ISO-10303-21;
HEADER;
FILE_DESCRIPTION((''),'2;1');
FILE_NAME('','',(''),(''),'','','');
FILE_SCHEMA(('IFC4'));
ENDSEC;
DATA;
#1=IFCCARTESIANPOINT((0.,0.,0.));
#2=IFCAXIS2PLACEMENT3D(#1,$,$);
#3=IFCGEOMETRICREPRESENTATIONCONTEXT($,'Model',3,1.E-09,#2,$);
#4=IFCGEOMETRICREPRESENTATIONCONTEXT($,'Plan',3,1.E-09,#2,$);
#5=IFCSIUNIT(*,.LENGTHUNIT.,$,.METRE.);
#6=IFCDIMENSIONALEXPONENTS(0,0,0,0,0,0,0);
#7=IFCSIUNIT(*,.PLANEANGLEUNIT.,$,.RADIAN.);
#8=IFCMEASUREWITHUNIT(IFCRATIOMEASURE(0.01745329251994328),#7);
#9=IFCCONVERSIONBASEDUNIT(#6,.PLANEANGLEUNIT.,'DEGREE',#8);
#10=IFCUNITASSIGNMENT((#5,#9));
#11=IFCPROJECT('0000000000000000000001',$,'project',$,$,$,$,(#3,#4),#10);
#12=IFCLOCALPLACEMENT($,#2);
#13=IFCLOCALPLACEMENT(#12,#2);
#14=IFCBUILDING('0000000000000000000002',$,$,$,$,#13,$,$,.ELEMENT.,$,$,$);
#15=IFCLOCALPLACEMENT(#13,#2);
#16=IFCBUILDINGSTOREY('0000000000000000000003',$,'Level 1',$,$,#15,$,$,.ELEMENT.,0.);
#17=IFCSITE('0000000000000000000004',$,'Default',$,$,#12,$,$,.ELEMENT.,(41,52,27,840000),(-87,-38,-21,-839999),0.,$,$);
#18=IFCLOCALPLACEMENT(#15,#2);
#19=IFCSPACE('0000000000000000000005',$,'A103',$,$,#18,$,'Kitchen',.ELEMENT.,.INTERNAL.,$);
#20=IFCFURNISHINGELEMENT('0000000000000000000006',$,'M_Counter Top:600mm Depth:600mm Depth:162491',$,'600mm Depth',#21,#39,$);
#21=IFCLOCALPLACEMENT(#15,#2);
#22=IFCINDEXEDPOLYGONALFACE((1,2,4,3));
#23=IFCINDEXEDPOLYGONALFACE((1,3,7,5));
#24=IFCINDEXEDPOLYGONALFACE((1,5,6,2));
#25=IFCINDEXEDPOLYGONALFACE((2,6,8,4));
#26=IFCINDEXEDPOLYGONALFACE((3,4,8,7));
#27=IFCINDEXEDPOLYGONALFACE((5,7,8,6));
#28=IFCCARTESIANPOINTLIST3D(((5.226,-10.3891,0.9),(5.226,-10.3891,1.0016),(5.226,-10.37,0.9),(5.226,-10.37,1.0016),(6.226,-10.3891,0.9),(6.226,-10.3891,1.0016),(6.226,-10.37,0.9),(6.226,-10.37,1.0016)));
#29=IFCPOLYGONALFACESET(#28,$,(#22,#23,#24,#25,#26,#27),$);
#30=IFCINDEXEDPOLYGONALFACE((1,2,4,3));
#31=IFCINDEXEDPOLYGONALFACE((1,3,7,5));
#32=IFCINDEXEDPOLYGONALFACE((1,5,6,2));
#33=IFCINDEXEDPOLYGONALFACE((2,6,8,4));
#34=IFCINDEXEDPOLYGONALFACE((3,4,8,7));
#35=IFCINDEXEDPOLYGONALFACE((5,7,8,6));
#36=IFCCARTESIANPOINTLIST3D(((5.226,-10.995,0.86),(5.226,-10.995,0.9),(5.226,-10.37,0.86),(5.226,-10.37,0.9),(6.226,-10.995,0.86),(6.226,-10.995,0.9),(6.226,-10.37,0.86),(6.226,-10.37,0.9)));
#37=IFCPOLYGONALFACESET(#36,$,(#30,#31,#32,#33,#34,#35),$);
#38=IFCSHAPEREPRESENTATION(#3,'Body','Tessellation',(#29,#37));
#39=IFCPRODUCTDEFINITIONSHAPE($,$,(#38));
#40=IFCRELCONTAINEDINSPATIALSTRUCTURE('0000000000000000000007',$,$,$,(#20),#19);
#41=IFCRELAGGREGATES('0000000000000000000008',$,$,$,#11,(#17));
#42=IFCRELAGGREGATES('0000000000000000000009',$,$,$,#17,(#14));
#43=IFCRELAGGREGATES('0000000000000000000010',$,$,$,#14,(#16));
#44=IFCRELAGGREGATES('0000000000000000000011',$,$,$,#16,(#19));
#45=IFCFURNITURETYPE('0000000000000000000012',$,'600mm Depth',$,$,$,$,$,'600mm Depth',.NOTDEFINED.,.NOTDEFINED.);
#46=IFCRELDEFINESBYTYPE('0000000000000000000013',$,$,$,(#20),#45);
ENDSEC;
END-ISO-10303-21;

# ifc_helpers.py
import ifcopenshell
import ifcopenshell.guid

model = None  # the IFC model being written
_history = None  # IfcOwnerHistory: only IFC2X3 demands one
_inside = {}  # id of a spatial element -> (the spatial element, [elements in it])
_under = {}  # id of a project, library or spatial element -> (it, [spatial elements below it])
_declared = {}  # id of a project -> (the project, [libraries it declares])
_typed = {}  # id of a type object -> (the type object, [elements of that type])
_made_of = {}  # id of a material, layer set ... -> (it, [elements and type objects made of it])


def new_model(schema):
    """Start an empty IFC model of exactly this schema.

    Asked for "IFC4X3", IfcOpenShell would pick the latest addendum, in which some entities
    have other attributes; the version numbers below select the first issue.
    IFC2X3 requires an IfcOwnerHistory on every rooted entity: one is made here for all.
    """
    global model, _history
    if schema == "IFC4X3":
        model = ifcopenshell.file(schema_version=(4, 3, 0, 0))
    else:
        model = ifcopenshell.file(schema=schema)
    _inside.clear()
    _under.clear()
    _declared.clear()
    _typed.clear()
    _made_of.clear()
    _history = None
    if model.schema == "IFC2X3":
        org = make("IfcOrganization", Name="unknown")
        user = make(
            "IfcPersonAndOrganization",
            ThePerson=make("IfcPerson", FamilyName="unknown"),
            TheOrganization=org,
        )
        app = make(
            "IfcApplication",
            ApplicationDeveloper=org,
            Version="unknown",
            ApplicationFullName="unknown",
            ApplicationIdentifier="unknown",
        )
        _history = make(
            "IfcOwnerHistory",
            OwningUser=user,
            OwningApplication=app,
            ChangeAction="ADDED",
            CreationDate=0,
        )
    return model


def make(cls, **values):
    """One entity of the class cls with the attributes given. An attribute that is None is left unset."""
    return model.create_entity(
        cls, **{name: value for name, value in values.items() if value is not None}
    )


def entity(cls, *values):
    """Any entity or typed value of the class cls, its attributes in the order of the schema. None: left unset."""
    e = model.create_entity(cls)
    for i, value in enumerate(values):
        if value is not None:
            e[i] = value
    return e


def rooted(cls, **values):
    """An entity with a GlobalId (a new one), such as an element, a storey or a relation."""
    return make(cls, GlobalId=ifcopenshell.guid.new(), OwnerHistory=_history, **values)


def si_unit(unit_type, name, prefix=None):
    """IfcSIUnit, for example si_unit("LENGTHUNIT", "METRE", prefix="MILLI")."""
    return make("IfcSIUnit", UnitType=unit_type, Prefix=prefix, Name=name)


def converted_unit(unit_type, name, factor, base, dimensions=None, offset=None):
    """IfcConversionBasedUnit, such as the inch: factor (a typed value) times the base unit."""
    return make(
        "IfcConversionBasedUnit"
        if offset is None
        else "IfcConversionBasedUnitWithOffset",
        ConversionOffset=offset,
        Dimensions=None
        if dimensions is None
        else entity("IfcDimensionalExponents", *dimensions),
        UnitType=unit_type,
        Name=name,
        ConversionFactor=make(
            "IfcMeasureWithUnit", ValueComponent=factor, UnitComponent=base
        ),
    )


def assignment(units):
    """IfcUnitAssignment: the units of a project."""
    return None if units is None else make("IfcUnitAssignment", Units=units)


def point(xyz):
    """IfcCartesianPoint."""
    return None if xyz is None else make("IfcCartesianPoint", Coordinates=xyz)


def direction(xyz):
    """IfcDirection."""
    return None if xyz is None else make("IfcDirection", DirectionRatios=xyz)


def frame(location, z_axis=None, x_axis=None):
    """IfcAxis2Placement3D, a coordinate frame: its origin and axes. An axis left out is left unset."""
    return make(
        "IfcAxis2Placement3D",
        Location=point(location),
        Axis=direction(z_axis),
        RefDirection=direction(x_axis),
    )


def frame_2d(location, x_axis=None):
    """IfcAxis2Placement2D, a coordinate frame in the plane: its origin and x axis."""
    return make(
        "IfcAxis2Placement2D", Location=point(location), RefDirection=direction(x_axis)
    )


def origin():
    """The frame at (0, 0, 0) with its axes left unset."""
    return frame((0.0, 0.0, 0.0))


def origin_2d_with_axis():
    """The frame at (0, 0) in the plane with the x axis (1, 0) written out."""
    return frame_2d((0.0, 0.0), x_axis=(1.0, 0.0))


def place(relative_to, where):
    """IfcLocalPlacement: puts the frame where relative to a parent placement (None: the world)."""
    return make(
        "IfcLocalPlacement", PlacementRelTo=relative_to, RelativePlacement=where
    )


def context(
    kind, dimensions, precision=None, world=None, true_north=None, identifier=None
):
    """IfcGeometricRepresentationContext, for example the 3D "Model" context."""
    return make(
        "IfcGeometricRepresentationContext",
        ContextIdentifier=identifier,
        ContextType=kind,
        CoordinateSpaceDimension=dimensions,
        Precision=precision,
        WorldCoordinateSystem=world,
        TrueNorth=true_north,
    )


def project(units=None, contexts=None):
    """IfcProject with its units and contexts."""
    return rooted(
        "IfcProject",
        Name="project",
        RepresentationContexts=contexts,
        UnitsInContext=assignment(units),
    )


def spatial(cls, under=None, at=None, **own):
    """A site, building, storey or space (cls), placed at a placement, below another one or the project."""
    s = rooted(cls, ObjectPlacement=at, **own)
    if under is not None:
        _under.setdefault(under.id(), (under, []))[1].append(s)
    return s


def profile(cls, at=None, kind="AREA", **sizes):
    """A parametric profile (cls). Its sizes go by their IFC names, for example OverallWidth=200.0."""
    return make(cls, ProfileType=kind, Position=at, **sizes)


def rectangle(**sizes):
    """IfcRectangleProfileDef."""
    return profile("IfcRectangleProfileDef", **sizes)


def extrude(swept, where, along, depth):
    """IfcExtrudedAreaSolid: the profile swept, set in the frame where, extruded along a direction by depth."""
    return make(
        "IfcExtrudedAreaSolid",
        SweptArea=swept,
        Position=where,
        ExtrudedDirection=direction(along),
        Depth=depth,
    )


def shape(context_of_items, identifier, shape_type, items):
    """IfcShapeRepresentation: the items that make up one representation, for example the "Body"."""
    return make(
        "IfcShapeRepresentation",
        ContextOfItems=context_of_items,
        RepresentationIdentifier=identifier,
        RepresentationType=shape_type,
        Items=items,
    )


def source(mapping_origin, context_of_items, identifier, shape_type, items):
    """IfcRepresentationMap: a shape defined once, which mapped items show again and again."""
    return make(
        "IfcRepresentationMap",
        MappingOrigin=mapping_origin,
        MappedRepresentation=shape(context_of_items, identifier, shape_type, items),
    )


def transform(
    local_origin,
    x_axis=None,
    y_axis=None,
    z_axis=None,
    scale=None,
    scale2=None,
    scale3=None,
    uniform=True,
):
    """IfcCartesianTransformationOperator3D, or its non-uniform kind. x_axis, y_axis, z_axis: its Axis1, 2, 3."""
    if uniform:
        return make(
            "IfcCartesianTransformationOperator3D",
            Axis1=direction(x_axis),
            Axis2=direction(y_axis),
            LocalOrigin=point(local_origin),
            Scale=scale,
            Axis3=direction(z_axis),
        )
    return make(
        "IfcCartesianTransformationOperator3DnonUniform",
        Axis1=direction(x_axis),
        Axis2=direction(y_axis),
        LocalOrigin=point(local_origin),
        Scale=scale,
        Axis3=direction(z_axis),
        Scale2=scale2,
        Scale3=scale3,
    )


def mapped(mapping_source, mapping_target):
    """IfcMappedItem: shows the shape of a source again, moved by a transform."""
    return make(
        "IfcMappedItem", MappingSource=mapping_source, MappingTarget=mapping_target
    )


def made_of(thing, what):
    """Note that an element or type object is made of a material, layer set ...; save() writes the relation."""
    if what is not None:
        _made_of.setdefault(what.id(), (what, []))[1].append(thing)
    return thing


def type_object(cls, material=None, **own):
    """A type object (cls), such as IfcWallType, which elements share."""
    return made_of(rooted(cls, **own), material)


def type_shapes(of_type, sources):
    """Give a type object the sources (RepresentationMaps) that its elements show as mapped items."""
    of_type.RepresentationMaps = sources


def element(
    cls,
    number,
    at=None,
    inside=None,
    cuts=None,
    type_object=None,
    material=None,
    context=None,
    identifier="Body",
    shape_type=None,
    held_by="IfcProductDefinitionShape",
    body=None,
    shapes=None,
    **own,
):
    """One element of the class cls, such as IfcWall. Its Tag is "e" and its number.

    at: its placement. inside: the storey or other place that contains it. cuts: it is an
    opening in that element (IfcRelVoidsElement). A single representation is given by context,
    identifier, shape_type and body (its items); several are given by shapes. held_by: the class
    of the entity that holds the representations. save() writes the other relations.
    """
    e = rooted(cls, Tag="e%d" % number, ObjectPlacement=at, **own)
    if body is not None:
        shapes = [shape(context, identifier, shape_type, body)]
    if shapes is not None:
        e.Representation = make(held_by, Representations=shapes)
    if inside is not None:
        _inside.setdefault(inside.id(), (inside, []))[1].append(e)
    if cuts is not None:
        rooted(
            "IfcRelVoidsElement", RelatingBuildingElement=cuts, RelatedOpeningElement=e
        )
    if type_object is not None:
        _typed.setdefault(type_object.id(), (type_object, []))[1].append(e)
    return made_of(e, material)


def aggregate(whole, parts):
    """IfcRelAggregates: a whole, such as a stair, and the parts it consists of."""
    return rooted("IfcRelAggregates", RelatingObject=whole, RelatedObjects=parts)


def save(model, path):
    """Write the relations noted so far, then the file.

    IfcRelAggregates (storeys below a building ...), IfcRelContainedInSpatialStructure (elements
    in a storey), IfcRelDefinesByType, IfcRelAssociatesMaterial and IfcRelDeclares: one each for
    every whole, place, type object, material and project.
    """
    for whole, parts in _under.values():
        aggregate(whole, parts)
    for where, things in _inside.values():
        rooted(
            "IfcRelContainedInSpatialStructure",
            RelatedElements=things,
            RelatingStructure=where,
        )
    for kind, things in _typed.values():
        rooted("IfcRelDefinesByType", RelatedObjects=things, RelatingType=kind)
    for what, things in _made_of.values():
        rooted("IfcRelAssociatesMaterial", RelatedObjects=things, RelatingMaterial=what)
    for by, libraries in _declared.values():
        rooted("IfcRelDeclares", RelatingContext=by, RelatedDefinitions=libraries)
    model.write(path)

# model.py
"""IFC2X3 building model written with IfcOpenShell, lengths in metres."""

from ifc_helpers import new_model, entity, si_unit, converted_unit, frame, origin, origin_2d_with_axis, place, context, project, spatial, rectangle, extrude, source, transform, mapped, type_object, type_shapes, element, save


model = new_model("IFC2X3")

# Units and contexts
model_context = context("Model", 3, precision=1e-09, world=origin())
plan_context = context("Plan", 3, precision=1e-09, world=origin())
ifc_project = project(units=[si_unit("LENGTHUNIT", "METRE"), converted_unit("PLANEANGLEUNIT", "DEGREE", entity("IfcRatioMeasure", 0.01745329251994328), si_unit("PLANEANGLEUNIT", "RADIAN"), dimensions=[0, 0, 0, 0, 0, 0, 0])], contexts=[model_context, plan_context])

# Site, building, storey
site_placement = place(None, origin())
site = spatial("IfcSite", under=ifc_project, at=site_placement, Name="Default", CompositionType="ELEMENT", RefLatitude=(41, 52, 27, 840000), RefLongitude=(-87, -38, -21, -839999), RefElevation=0.0)
building_placement = place(site_placement, origin())
building = spatial("IfcBuilding", under=site, at=building_placement, CompositionType="ELEMENT")
storey_placement = place(building_placement, origin())
storey = spatial("IfcBuildingStorey", under=building, at=storey_placement, Name="Level 1", CompositionType="ELEMENT", Elevation=0.0)

# Shared definitions
space_placement = place(storey_placement, origin())
space = spatial("IfcSpace", under=storey, at=space_placement, Name="A103", LongName="Kitchen", CompositionType="ELEMENT", InteriorOrExteriorSpace="INTERNAL")

# Furnishing element
furniture_type_1 = type_object("IfcFurnitureType", Name="600mm Depth", ElementType="600mm Depth", AssemblyPlace="NOTDEFINED")
shared_shape_1 = source(origin(), model_context, "Body", "SweptSolid", [
    extrude(rectangle(XDim=0.0191, YDim=1.0, at=origin_2d_with_axis()), frame((-0.7005, -0.0095, 0.9), z_axis=(0.0, 0.0, 1.0), x_axis=(0.0, -1.0, 0.0)), (0.0, 0.0, 1.0), 0.1016),
    extrude(rectangle(XDim=1.0, YDim=0.625, at=origin_2d_with_axis()), frame((-0.7005, -0.3125, 0.86), z_axis=(0.0, 0.0, 1.0), x_axis=(-1.0, 0.0, 0.0)), (0.0, 0.0, 1.0), 0.04),
])
type_shapes(furniture_type_1, [shared_shape_1])
furnishing_1_placement = place(space_placement, frame((6.4265, -10.37, 0.0)))
element("IfcFurnishingElement", 1, at=furnishing_1_placement, inside=space, type_object=furniture_type_1, Name="M_Counter Top:600mm Depth:600mm Depth:162491", ObjectType="600mm Depth", context=model_context, shape_type="MappedRepresentation", body=[
    mapped(shared_shape_1, transform((0.0, 0.0, 0.0), scale=1.0)),
])

save(model, "model.ifc")
